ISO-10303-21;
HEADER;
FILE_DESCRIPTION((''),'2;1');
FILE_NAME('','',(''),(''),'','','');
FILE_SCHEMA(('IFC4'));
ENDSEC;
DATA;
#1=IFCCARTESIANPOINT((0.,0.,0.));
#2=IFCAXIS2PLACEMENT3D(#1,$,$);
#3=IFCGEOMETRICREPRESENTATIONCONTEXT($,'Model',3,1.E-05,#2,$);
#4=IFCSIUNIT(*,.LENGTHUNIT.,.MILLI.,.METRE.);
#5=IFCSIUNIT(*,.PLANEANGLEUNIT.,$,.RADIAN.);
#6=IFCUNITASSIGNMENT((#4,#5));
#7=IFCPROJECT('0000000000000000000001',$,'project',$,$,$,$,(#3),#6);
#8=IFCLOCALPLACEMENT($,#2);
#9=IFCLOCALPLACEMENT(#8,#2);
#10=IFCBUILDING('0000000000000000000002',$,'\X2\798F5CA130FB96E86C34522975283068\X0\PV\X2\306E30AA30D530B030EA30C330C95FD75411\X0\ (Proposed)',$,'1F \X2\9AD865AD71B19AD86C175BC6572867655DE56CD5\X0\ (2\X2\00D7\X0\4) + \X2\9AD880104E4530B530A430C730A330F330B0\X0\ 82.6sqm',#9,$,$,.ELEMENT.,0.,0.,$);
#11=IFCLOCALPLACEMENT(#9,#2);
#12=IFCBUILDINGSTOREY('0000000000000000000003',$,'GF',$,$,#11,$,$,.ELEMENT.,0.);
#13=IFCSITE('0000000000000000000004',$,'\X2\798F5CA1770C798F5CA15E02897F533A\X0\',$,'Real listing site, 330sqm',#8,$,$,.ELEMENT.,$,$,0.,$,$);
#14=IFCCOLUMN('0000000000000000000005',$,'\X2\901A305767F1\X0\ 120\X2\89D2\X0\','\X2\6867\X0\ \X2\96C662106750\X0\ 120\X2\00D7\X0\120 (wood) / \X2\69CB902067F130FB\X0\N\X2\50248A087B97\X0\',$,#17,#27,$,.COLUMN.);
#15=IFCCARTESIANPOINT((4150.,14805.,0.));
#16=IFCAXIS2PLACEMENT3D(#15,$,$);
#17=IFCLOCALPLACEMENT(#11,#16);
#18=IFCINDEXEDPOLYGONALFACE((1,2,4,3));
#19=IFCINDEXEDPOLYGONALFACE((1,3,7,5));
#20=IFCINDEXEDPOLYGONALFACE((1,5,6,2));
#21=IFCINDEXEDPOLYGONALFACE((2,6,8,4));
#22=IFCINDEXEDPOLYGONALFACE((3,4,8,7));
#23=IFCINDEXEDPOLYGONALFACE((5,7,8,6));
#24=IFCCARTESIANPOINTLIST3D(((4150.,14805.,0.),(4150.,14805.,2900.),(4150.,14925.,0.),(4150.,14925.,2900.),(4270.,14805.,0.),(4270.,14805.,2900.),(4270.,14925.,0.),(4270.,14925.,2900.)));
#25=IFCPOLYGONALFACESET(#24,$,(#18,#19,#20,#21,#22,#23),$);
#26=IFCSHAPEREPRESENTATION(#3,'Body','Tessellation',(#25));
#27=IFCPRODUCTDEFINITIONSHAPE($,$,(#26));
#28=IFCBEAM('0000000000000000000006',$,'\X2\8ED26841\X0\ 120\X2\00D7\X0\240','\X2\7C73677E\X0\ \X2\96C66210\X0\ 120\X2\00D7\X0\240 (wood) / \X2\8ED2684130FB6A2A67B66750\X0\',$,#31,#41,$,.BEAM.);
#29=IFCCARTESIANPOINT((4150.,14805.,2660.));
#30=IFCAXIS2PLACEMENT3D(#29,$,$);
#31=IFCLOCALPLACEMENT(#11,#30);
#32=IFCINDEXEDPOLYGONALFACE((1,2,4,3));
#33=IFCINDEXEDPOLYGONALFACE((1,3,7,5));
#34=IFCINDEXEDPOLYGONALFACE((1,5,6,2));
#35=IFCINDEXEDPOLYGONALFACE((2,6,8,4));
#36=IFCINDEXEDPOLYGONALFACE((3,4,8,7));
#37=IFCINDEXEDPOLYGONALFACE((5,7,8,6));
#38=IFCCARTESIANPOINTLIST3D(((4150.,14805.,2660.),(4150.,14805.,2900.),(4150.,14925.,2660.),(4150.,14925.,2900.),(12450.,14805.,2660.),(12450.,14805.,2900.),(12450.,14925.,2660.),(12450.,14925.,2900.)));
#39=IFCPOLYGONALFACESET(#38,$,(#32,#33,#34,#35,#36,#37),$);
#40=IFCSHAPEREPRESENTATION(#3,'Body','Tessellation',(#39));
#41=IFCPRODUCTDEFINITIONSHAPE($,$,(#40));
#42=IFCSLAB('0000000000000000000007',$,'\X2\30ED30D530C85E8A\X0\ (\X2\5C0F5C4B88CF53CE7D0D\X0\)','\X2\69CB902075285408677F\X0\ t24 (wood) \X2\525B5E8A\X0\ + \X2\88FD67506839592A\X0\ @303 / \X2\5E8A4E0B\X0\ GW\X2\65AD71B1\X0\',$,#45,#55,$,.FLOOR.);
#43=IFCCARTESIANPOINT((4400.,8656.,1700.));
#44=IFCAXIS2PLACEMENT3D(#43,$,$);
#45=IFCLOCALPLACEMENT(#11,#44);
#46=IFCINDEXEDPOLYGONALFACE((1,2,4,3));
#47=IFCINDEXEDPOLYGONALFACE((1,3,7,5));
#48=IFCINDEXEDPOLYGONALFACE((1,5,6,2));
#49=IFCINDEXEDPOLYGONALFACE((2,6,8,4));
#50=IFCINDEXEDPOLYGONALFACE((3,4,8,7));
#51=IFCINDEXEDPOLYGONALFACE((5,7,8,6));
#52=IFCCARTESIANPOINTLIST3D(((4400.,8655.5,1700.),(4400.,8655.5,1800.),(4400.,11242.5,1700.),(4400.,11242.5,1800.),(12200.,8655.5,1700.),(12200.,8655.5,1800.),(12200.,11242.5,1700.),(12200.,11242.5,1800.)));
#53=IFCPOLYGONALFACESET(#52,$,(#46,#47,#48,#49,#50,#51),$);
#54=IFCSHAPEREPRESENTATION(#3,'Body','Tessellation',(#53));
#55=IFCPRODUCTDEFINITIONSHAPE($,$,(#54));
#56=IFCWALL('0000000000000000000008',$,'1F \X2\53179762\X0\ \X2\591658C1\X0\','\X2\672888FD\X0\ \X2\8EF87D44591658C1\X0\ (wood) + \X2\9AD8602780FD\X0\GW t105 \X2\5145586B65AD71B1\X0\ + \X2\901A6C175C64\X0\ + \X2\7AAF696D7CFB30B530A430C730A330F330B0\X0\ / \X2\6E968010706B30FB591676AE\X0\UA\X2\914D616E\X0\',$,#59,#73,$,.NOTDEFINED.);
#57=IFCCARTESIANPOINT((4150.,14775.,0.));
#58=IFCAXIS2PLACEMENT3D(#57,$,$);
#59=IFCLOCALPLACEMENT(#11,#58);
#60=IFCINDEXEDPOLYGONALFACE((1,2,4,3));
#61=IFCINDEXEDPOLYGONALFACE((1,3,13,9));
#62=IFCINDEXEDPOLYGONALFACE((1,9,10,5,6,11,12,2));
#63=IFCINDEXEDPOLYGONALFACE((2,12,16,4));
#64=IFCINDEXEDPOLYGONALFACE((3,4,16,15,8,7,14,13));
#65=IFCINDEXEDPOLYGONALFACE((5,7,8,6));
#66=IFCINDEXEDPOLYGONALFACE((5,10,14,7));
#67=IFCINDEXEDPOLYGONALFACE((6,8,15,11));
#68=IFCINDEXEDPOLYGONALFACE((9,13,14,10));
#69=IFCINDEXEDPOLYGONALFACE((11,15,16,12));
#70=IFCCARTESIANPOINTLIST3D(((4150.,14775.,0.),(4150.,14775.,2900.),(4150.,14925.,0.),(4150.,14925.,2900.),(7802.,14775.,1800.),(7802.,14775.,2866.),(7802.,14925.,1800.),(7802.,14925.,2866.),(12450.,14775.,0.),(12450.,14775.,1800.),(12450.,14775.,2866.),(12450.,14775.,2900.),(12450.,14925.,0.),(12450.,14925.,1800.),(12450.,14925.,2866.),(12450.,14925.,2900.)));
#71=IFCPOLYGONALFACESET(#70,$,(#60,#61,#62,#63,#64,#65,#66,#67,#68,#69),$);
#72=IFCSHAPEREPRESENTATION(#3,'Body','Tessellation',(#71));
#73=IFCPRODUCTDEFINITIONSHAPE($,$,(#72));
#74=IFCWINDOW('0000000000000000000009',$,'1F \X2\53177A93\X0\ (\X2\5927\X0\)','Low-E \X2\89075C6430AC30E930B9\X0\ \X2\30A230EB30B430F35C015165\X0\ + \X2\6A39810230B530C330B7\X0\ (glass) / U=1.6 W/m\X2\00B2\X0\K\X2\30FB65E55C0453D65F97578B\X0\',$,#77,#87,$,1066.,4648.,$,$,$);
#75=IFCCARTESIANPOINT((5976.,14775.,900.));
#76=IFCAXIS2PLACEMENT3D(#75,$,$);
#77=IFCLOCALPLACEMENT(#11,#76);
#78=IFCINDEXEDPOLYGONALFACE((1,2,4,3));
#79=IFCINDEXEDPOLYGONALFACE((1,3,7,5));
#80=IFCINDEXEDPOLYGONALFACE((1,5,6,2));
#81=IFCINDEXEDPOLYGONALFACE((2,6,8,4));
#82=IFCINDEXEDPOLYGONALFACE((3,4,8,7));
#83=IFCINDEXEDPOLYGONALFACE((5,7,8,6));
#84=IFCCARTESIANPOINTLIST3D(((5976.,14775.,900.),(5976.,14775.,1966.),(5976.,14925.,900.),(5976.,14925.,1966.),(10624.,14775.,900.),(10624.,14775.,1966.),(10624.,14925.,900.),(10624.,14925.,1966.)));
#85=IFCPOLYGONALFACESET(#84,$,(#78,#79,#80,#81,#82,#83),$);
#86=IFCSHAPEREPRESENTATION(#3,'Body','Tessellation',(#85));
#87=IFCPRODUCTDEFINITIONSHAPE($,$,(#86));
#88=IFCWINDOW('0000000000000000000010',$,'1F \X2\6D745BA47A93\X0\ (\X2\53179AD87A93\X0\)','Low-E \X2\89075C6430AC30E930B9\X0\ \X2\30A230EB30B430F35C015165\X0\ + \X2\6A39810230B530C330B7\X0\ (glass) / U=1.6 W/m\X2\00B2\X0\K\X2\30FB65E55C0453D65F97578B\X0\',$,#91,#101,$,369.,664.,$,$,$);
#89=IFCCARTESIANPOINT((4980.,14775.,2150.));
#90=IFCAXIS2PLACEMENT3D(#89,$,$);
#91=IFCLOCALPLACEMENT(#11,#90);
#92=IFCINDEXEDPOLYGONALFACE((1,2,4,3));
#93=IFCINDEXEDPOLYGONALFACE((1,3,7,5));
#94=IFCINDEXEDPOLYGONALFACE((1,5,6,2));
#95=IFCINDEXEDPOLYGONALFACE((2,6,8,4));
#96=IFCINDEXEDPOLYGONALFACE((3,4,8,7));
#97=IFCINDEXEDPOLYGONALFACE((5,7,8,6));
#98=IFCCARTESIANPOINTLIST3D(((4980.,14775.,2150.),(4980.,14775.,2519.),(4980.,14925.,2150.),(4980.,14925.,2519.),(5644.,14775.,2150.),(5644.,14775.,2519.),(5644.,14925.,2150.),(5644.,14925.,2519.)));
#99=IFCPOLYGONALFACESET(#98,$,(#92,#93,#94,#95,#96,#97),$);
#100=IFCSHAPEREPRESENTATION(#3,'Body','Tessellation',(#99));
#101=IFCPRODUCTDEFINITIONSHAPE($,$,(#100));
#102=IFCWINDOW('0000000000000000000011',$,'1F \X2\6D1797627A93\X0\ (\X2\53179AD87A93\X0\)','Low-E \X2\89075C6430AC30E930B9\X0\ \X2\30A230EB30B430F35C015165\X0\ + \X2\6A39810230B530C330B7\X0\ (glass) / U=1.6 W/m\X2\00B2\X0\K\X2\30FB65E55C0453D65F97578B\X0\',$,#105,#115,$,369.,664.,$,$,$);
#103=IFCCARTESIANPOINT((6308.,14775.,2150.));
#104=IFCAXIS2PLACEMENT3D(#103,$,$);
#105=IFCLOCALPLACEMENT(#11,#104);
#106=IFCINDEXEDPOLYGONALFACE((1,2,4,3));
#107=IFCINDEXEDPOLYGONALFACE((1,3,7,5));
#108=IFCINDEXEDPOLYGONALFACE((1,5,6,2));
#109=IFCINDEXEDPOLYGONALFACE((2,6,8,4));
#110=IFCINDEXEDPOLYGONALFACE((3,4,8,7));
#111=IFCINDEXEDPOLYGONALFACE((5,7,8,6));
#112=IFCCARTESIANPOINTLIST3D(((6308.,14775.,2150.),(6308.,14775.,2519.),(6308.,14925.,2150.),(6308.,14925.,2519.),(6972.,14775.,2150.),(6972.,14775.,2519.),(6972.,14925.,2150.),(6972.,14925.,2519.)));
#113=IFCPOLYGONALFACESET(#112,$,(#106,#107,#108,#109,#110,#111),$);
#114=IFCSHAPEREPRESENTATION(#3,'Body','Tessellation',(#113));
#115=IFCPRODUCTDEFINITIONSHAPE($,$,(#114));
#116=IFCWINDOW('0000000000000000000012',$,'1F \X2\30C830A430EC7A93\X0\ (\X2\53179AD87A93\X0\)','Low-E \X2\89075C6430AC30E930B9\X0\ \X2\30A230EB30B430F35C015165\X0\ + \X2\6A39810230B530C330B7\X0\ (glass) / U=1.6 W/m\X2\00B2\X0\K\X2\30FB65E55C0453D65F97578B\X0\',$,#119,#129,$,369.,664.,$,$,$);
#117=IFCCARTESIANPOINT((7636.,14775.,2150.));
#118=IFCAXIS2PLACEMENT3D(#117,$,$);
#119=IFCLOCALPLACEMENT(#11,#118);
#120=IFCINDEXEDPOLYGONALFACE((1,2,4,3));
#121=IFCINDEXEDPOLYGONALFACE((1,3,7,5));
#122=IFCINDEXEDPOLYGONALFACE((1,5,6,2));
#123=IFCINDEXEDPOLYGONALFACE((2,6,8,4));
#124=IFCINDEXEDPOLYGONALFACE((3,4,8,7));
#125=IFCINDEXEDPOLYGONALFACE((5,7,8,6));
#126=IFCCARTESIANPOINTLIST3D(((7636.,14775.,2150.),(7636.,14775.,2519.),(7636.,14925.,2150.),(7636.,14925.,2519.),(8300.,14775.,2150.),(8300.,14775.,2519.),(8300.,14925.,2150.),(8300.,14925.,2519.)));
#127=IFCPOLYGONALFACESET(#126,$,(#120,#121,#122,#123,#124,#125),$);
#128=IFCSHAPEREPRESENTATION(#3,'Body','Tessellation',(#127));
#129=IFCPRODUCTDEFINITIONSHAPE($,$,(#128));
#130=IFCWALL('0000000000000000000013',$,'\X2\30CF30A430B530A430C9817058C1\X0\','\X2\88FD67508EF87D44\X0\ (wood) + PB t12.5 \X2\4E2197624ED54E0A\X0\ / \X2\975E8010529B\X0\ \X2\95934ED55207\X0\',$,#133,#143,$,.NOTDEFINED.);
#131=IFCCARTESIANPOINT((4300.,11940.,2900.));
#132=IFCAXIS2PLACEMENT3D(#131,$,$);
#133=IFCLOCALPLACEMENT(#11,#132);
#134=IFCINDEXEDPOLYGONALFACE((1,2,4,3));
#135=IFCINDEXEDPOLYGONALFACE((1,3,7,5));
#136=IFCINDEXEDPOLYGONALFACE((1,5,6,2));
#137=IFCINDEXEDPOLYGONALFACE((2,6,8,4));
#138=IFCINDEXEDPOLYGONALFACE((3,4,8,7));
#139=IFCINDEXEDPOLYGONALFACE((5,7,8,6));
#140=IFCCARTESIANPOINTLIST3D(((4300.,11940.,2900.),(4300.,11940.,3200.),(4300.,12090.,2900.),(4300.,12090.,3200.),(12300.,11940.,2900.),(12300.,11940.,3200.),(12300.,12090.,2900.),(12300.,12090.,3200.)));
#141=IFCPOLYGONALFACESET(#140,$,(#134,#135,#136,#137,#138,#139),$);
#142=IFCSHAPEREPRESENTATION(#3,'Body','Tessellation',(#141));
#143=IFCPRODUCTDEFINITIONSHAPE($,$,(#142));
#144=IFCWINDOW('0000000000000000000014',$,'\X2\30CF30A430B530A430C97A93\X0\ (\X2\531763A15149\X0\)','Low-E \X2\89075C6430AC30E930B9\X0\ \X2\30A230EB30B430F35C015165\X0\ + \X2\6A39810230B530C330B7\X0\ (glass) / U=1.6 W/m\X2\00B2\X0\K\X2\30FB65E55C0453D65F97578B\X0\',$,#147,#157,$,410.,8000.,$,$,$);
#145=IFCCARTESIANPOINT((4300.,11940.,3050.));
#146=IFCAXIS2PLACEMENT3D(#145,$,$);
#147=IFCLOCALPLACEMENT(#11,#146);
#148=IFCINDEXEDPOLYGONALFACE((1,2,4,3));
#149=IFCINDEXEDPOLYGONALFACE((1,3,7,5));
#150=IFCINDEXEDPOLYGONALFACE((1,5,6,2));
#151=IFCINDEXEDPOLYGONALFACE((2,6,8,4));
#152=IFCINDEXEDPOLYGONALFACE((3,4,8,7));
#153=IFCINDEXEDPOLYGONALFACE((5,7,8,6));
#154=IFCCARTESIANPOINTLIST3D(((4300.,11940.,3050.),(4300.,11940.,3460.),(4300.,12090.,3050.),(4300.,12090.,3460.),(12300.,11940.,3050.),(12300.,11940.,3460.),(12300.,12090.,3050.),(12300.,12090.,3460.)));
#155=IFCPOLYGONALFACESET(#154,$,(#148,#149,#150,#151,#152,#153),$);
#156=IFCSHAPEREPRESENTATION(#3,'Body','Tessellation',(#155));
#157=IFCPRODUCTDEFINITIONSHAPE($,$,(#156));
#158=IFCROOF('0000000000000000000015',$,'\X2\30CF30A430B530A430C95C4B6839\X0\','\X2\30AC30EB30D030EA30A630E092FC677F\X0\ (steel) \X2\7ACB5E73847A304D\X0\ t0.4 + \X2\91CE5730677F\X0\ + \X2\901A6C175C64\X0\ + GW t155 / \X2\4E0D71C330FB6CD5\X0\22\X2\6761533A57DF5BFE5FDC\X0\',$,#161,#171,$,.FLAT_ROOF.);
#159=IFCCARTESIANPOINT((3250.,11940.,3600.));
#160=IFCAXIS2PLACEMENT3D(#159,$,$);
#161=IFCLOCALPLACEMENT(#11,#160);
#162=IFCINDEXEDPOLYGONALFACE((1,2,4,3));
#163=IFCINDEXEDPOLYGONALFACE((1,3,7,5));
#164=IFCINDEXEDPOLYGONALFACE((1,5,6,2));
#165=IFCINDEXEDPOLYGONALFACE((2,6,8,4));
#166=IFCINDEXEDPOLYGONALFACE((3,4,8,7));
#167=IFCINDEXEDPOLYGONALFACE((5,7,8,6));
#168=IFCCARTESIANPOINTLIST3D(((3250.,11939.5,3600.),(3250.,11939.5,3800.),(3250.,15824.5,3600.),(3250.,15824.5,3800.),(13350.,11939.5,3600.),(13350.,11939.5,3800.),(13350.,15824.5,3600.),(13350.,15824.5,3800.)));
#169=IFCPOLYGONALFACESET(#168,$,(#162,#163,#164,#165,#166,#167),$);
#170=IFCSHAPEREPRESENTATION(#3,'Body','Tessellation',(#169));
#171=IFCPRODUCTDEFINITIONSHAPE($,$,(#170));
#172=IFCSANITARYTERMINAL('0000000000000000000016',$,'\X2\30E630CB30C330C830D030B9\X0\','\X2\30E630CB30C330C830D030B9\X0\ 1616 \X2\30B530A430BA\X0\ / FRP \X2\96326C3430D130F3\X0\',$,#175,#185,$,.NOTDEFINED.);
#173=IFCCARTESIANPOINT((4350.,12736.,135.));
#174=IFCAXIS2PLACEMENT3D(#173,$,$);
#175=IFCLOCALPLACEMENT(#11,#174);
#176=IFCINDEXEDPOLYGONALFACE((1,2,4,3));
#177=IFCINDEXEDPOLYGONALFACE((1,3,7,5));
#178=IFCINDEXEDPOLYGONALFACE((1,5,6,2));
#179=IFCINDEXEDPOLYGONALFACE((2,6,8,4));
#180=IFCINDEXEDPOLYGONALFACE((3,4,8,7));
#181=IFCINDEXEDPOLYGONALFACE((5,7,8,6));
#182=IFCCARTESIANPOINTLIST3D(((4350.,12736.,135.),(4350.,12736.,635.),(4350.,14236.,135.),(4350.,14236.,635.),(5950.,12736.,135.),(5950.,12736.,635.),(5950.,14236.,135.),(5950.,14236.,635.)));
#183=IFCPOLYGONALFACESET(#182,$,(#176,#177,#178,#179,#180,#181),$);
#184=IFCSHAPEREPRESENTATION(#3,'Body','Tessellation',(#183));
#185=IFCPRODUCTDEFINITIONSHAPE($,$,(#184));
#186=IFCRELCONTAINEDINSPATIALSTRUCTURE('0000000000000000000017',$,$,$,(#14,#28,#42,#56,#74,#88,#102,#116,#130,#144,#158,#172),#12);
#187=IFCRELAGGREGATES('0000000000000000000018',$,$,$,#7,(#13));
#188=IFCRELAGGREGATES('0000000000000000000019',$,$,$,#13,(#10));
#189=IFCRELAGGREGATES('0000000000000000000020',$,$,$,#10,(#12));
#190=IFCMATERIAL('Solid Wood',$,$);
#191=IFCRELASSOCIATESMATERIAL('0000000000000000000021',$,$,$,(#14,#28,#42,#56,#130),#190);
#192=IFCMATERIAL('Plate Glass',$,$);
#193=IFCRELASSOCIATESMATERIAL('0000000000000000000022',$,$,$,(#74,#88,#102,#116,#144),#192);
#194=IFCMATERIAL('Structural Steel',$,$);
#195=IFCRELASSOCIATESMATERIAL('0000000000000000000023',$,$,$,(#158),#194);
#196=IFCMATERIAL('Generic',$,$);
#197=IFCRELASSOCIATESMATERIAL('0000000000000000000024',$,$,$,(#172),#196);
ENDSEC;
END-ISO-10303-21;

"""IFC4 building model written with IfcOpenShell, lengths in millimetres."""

from ifc_helpers import new_model, si_unit, frame, frame_2d, origin, place, context, project, spatial, rectangle, extrude, material, element, fill, save


model = new_model("IFC4")

# Units and contexts
model_context = context("Model", 3, precision=1e-05, world=origin())
ifc_project = project(units=[si_unit("LENGTHUNIT", "METRE", prefix="MILLI"), si_unit("PLANEANGLEUNIT", "RADIAN")], contexts=[model_context])

# Site, building, storey
site_placement = place(None, origin())
site = spatial("IfcSite", under=ifc_project, at=site_placement, Name="福岡県福岡市西区", ObjectType="Real listing site, 330sqm", CompositionType="ELEMENT", RefElevation=0.0)
building_placement = place(site_placement, origin())
building = spatial("IfcBuilding", under=site, at=building_placement, Name="福岡・雨水利用とPVのオフグリッド志向 (Proposed)", ObjectType="1F 高断熱高気密在来工法 (2×4) + 高耐久サイディング 82.6sqm", CompositionType="ELEMENT", ElevationOfRefHeight=0.0, ElevationOfTerrain=0.0)
storey_placement = place(building_placement, origin())
storey = spatial("IfcBuildingStorey", under=building, at=storey_placement, Name="GF", CompositionType="ELEMENT", Elevation=0.0)

# Column
ifc_material_1 = material(Name="Solid Wood")
column_1_placement = place(storey_placement, frame((4150.0, 14805.0, 0.0)))
element("IfcColumn", 1, at=column_1_placement, inside=storey, material=ifc_material_1, Name="通し柱 120角", Description="桧 集成材 120×120 (wood) / 構造柱・N値計算", PredefinedType="COLUMN", context=model_context, shape_type="SweptSolid", body=[
    extrude(rectangle(XDim=120.0, YDim=120.0, at=frame_2d((60.0, 60.0))), frame((4150.0, 14805.0, 0.0)), (0.0, 0.0, 1.0), 2900.0),
])

# Beam
beam_1_placement = place(storey_placement, frame((4150.0, 14805.0, 2660.0)))
element("IfcBeam", 2, at=beam_1_placement, inside=storey, material=ifc_material_1, Name="軒桁 120×240", Description="米松 集成 120×240 (wood) / 軒桁・横架材", PredefinedType="BEAM", context=model_context, shape_type="SweptSolid", body=[
    extrude(rectangle(XDim=8300.0, YDim=120.0, at=frame_2d((4150.0, 60.0))), frame((4150.0, 14805.0, 2660.0)), (0.0, 0.0, 1.0), 240.0),
])

# Slab
slab_placement = place(storey_placement, frame((4400.0, 8656.0, 1700.0)))
element("IfcSlab", 3, at=slab_placement, inside=storey, material=ifc_material_1, Name="ロフト床 (小屋裏収納)", Description="構造用合板 t24 (wood) 剛床 + 製材根太 @303 / 床下 GW断熱", PredefinedType="FLOOR", context=model_context, shape_type="SweptSolid", body=[
    extrude(rectangle(XDim=7800.0, YDim=2587.0, at=frame_2d((3900.0, 1293.0))), frame((4400.0, 8656.0, 1700.0)), (0.0, 0.0, 1.0), 100.0),
])

# Wall, openings, windows
wall_1_placement = place(storey_placement, frame((4150.0, 14775.0, 0.0)))
wall_1 = element("IfcWall", 4, at=wall_1_placement, inside=storey, material=ifc_material_1, Name="1F 北面 外壁", Description="木製 軸組外壁 (wood) + 高性能GW t105 充填断熱 + 通気層 + 窯業系サイディング / 準耐火・外皮UA配慮", PredefinedType="NOTDEFINED", context=model_context, shape_type="SweptSolid", body=[
    extrude(rectangle(XDim=8300.0, YDim=150.0, at=frame_2d((4150.0, 75.0))), frame((4150.0, 14775.0, 0.0)), (0.0, 0.0, 1.0), 2900.0),
])
opening_1_placement = place(storey_placement, frame((5976.0, 14775.0, 900.0)))
opening_1 = element("IfcOpeningElement", 5, at=opening_1_placement, cuts=wall_1, PredefinedType="NOTDEFINED", context=model_context, shape_type="SweptSolid", body=[
    extrude(rectangle(XDim=4648.0, YDim=150.0, at=frame_2d((2324.0, 75.0))), frame((5976.0, 14775.0, 900.0)), (0.0, 0.0, 1.0), 1066.0),
])
opening_2_placement = place(storey_placement, frame((4980.0, 14775.0, 2150.0)))
opening_2 = element("IfcOpeningElement", 6, at=opening_2_placement, cuts=wall_1, PredefinedType="NOTDEFINED", context=model_context, shape_type="SweptSolid", body=[
    extrude(rectangle(XDim=664.0, YDim=150.0, at=frame_2d((332.0, 75.0))), frame((4980.0, 14775.0, 2150.0)), (0.0, 0.0, 1.0), 369.0),
])
opening_3_placement = place(storey_placement, frame((6308.0, 14775.0, 2150.0)))
opening_3 = element("IfcOpeningElement", 7, at=opening_3_placement, cuts=wall_1, PredefinedType="NOTDEFINED", context=model_context, shape_type="SweptSolid", body=[
    extrude(rectangle(XDim=664.0, YDim=150.0, at=frame_2d((332.0, 75.0))), frame((6308.0, 14775.0, 2150.0)), (0.0, 0.0, 1.0), 369.0),
])
opening_4_placement = place(storey_placement, frame((7636.0, 14775.0, 2150.0)))
opening_4 = element("IfcOpeningElement", 8, at=opening_4_placement, cuts=wall_1, PredefinedType="NOTDEFINED", context=model_context, shape_type="SweptSolid", body=[
    extrude(rectangle(XDim=664.0, YDim=150.0, at=frame_2d((332.0, 75.0))), frame((7636.0, 14775.0, 2150.0)), (0.0, 0.0, 1.0), 369.0),
])
ifc_material_2 = material(Name="Plate Glass")
window_1_placement = place(storey_placement, frame((5976.0, 14775.0, 900.0)))
window_1 = element("IfcWindow", 9, at=window_1_placement, inside=storey, material=ifc_material_2, Name="1F 北窓 (大)", Description="Low-E 複層ガラス アルゴン封入 + 樹脂サッシ (glass) / U=1.6 W/m²K・日射取得型", OverallHeight=1066.0, OverallWidth=4648.0, context=model_context, shape_type="SweptSolid", body=[
    extrude(rectangle(XDim=4648.0, YDim=150.0, at=frame_2d((2324.0, 75.0))), frame((5976.0, 14775.0, 900.0)), (0.0, 0.0, 1.0), 1066.0),
])
fill(opening_1, window_1)
window_2_placement = place(storey_placement, frame((4980.0, 14775.0, 2150.0)))
window_2 = element("IfcWindow", 10, at=window_2_placement, inside=storey, material=ifc_material_2, Name="1F 浴室窓 (北高窓)", Description="Low-E 複層ガラス アルゴン封入 + 樹脂サッシ (glass) / U=1.6 W/m²K・日射取得型", OverallHeight=369.0, OverallWidth=664.0, context=model_context, shape_type="SweptSolid", body=[
    extrude(rectangle(XDim=664.0, YDim=150.0, at=frame_2d((332.0, 75.0))), frame((4980.0, 14775.0, 2150.0)), (0.0, 0.0, 1.0), 369.0),
])
fill(opening_2, window_2)
window_3_placement = place(storey_placement, frame((6308.0, 14775.0, 2150.0)))
window_3 = element("IfcWindow", 11, at=window_3_placement, inside=storey, material=ifc_material_2, Name="1F 洗面窓 (北高窓)", Description="Low-E 複層ガラス アルゴン封入 + 樹脂サッシ (glass) / U=1.6 W/m²K・日射取得型", OverallHeight=369.0, OverallWidth=664.0, context=model_context, shape_type="SweptSolid", body=[
    extrude(rectangle(XDim=664.0, YDim=150.0, at=frame_2d((332.0, 75.0))), frame((6308.0, 14775.0, 2150.0)), (0.0, 0.0, 1.0), 369.0),
])
fill(opening_3, window_3)
window_4_placement = place(storey_placement, frame((7636.0, 14775.0, 2150.0)))
window_4 = element("IfcWindow", 12, at=window_4_placement, inside=storey, material=ifc_material_2, Name="1F トイレ窓 (北高窓)", Description="Low-E 複層ガラス アルゴン封入 + 樹脂サッシ (glass) / U=1.6 W/m²K・日射取得型", OverallHeight=369.0, OverallWidth=664.0, context=model_context, shape_type="SweptSolid", body=[
    extrude(rectangle(XDim=664.0, YDim=150.0, at=frame_2d((332.0, 75.0))), frame((7636.0, 14775.0, 2150.0)), (0.0, 0.0, 1.0), 369.0),
])
fill(opening_4, window_4)

# Wall, opening, window
wall_2_placement = place(storey_placement, frame((4300.0, 11940.0, 2900.0)))
wall_2 = element("IfcWall", 13, at=wall_2_placement, inside=storey, material=ifc_material_1, Name="ハイサイド腰壁", Description="製材軸組 (wood) + PB t12.5 両面仕上 / 非耐力 間仕切", PredefinedType="NOTDEFINED", context=model_context, shape_type="SweptSolid", body=[
    extrude(rectangle(XDim=8000.0, YDim=150.0, at=frame_2d((4000.0, 75.0))), frame((4300.0, 11940.0, 2900.0)), (0.0, 0.0, 1.0), 700.0),
])
opening_5_placement = place(storey_placement, frame((4300.0, 11940.0, 3050.0)))
opening_5 = element("IfcOpeningElement", 14, at=opening_5_placement, cuts=wall_2, PredefinedType="NOTDEFINED", context=model_context, shape_type="SweptSolid", body=[
    extrude(rectangle(XDim=8000.0, YDim=150.0, at=frame_2d((4000.0, 75.0))), frame((4300.0, 11940.0, 3050.0)), (0.0, 0.0, 1.0), 410.0),
])
window_5_placement = place(storey_placement, frame((4300.0, 11940.0, 3050.0)))
window_5 = element("IfcWindow", 15, at=window_5_placement, inside=storey, material=ifc_material_2, Name="ハイサイド窓 (北採光)", Description="Low-E 複層ガラス アルゴン封入 + 樹脂サッシ (glass) / U=1.6 W/m²K・日射取得型", OverallHeight=410.0, OverallWidth=8000.0, context=model_context, shape_type="SweptSolid", body=[
    extrude(rectangle(XDim=8000.0, YDim=150.0, at=frame_2d((4000.0, 75.0))), frame((4300.0, 11940.0, 3050.0)), (0.0, 0.0, 1.0), 410.0),
])
fill(opening_5, window_5)

# Roof
ifc_material_3 = material(Name="Structural Steel")
roof_placement = place(storey_placement, frame((3250.0, 11940.0, 3600.0)))
element("IfcRoof", 16, at=roof_placement, inside=storey, material=ifc_material_3, Name="ハイサイド屋根", Description="ガルバリウム鋼板 (steel) 立平葺き t0.4 + 野地板 + 通気層 + GW t155 / 不燃・法22条区域対応", PredefinedType="FLAT_ROOF", context=model_context, shape_type="SweptSolid", body=[
    extrude(rectangle(XDim=10100.0, YDim=3885.0, at=frame_2d((5050.0, 1942.0))), frame((3250.0, 11940.0, 3600.0)), (0.0, 0.0, 1.0), 200.0),
])

# Sanitary terminal
ifc_material_4 = material(Name="Generic")
sanitary_terminal_placement = place(storey_placement, frame((4350.0, 12736.0, 135.0)))
element("IfcSanitaryTerminal", 17, at=sanitary_terminal_placement, inside=storey, material=ifc_material_4, Name="ユニットバス", Description="ユニットバス 1616 サイズ / FRP 防水パン", PredefinedType="NOTDEFINED", context=model_context, shape_type="SweptSolid", body=[
    extrude(rectangle(XDim=1600.0, YDim=1500.0, at=frame_2d((800.0, 750.0))), frame((4350.0, 12736.0, 135.0)), (0.0, 0.0, 1.0), 500.0),
])

save(model, "model.ifc")
